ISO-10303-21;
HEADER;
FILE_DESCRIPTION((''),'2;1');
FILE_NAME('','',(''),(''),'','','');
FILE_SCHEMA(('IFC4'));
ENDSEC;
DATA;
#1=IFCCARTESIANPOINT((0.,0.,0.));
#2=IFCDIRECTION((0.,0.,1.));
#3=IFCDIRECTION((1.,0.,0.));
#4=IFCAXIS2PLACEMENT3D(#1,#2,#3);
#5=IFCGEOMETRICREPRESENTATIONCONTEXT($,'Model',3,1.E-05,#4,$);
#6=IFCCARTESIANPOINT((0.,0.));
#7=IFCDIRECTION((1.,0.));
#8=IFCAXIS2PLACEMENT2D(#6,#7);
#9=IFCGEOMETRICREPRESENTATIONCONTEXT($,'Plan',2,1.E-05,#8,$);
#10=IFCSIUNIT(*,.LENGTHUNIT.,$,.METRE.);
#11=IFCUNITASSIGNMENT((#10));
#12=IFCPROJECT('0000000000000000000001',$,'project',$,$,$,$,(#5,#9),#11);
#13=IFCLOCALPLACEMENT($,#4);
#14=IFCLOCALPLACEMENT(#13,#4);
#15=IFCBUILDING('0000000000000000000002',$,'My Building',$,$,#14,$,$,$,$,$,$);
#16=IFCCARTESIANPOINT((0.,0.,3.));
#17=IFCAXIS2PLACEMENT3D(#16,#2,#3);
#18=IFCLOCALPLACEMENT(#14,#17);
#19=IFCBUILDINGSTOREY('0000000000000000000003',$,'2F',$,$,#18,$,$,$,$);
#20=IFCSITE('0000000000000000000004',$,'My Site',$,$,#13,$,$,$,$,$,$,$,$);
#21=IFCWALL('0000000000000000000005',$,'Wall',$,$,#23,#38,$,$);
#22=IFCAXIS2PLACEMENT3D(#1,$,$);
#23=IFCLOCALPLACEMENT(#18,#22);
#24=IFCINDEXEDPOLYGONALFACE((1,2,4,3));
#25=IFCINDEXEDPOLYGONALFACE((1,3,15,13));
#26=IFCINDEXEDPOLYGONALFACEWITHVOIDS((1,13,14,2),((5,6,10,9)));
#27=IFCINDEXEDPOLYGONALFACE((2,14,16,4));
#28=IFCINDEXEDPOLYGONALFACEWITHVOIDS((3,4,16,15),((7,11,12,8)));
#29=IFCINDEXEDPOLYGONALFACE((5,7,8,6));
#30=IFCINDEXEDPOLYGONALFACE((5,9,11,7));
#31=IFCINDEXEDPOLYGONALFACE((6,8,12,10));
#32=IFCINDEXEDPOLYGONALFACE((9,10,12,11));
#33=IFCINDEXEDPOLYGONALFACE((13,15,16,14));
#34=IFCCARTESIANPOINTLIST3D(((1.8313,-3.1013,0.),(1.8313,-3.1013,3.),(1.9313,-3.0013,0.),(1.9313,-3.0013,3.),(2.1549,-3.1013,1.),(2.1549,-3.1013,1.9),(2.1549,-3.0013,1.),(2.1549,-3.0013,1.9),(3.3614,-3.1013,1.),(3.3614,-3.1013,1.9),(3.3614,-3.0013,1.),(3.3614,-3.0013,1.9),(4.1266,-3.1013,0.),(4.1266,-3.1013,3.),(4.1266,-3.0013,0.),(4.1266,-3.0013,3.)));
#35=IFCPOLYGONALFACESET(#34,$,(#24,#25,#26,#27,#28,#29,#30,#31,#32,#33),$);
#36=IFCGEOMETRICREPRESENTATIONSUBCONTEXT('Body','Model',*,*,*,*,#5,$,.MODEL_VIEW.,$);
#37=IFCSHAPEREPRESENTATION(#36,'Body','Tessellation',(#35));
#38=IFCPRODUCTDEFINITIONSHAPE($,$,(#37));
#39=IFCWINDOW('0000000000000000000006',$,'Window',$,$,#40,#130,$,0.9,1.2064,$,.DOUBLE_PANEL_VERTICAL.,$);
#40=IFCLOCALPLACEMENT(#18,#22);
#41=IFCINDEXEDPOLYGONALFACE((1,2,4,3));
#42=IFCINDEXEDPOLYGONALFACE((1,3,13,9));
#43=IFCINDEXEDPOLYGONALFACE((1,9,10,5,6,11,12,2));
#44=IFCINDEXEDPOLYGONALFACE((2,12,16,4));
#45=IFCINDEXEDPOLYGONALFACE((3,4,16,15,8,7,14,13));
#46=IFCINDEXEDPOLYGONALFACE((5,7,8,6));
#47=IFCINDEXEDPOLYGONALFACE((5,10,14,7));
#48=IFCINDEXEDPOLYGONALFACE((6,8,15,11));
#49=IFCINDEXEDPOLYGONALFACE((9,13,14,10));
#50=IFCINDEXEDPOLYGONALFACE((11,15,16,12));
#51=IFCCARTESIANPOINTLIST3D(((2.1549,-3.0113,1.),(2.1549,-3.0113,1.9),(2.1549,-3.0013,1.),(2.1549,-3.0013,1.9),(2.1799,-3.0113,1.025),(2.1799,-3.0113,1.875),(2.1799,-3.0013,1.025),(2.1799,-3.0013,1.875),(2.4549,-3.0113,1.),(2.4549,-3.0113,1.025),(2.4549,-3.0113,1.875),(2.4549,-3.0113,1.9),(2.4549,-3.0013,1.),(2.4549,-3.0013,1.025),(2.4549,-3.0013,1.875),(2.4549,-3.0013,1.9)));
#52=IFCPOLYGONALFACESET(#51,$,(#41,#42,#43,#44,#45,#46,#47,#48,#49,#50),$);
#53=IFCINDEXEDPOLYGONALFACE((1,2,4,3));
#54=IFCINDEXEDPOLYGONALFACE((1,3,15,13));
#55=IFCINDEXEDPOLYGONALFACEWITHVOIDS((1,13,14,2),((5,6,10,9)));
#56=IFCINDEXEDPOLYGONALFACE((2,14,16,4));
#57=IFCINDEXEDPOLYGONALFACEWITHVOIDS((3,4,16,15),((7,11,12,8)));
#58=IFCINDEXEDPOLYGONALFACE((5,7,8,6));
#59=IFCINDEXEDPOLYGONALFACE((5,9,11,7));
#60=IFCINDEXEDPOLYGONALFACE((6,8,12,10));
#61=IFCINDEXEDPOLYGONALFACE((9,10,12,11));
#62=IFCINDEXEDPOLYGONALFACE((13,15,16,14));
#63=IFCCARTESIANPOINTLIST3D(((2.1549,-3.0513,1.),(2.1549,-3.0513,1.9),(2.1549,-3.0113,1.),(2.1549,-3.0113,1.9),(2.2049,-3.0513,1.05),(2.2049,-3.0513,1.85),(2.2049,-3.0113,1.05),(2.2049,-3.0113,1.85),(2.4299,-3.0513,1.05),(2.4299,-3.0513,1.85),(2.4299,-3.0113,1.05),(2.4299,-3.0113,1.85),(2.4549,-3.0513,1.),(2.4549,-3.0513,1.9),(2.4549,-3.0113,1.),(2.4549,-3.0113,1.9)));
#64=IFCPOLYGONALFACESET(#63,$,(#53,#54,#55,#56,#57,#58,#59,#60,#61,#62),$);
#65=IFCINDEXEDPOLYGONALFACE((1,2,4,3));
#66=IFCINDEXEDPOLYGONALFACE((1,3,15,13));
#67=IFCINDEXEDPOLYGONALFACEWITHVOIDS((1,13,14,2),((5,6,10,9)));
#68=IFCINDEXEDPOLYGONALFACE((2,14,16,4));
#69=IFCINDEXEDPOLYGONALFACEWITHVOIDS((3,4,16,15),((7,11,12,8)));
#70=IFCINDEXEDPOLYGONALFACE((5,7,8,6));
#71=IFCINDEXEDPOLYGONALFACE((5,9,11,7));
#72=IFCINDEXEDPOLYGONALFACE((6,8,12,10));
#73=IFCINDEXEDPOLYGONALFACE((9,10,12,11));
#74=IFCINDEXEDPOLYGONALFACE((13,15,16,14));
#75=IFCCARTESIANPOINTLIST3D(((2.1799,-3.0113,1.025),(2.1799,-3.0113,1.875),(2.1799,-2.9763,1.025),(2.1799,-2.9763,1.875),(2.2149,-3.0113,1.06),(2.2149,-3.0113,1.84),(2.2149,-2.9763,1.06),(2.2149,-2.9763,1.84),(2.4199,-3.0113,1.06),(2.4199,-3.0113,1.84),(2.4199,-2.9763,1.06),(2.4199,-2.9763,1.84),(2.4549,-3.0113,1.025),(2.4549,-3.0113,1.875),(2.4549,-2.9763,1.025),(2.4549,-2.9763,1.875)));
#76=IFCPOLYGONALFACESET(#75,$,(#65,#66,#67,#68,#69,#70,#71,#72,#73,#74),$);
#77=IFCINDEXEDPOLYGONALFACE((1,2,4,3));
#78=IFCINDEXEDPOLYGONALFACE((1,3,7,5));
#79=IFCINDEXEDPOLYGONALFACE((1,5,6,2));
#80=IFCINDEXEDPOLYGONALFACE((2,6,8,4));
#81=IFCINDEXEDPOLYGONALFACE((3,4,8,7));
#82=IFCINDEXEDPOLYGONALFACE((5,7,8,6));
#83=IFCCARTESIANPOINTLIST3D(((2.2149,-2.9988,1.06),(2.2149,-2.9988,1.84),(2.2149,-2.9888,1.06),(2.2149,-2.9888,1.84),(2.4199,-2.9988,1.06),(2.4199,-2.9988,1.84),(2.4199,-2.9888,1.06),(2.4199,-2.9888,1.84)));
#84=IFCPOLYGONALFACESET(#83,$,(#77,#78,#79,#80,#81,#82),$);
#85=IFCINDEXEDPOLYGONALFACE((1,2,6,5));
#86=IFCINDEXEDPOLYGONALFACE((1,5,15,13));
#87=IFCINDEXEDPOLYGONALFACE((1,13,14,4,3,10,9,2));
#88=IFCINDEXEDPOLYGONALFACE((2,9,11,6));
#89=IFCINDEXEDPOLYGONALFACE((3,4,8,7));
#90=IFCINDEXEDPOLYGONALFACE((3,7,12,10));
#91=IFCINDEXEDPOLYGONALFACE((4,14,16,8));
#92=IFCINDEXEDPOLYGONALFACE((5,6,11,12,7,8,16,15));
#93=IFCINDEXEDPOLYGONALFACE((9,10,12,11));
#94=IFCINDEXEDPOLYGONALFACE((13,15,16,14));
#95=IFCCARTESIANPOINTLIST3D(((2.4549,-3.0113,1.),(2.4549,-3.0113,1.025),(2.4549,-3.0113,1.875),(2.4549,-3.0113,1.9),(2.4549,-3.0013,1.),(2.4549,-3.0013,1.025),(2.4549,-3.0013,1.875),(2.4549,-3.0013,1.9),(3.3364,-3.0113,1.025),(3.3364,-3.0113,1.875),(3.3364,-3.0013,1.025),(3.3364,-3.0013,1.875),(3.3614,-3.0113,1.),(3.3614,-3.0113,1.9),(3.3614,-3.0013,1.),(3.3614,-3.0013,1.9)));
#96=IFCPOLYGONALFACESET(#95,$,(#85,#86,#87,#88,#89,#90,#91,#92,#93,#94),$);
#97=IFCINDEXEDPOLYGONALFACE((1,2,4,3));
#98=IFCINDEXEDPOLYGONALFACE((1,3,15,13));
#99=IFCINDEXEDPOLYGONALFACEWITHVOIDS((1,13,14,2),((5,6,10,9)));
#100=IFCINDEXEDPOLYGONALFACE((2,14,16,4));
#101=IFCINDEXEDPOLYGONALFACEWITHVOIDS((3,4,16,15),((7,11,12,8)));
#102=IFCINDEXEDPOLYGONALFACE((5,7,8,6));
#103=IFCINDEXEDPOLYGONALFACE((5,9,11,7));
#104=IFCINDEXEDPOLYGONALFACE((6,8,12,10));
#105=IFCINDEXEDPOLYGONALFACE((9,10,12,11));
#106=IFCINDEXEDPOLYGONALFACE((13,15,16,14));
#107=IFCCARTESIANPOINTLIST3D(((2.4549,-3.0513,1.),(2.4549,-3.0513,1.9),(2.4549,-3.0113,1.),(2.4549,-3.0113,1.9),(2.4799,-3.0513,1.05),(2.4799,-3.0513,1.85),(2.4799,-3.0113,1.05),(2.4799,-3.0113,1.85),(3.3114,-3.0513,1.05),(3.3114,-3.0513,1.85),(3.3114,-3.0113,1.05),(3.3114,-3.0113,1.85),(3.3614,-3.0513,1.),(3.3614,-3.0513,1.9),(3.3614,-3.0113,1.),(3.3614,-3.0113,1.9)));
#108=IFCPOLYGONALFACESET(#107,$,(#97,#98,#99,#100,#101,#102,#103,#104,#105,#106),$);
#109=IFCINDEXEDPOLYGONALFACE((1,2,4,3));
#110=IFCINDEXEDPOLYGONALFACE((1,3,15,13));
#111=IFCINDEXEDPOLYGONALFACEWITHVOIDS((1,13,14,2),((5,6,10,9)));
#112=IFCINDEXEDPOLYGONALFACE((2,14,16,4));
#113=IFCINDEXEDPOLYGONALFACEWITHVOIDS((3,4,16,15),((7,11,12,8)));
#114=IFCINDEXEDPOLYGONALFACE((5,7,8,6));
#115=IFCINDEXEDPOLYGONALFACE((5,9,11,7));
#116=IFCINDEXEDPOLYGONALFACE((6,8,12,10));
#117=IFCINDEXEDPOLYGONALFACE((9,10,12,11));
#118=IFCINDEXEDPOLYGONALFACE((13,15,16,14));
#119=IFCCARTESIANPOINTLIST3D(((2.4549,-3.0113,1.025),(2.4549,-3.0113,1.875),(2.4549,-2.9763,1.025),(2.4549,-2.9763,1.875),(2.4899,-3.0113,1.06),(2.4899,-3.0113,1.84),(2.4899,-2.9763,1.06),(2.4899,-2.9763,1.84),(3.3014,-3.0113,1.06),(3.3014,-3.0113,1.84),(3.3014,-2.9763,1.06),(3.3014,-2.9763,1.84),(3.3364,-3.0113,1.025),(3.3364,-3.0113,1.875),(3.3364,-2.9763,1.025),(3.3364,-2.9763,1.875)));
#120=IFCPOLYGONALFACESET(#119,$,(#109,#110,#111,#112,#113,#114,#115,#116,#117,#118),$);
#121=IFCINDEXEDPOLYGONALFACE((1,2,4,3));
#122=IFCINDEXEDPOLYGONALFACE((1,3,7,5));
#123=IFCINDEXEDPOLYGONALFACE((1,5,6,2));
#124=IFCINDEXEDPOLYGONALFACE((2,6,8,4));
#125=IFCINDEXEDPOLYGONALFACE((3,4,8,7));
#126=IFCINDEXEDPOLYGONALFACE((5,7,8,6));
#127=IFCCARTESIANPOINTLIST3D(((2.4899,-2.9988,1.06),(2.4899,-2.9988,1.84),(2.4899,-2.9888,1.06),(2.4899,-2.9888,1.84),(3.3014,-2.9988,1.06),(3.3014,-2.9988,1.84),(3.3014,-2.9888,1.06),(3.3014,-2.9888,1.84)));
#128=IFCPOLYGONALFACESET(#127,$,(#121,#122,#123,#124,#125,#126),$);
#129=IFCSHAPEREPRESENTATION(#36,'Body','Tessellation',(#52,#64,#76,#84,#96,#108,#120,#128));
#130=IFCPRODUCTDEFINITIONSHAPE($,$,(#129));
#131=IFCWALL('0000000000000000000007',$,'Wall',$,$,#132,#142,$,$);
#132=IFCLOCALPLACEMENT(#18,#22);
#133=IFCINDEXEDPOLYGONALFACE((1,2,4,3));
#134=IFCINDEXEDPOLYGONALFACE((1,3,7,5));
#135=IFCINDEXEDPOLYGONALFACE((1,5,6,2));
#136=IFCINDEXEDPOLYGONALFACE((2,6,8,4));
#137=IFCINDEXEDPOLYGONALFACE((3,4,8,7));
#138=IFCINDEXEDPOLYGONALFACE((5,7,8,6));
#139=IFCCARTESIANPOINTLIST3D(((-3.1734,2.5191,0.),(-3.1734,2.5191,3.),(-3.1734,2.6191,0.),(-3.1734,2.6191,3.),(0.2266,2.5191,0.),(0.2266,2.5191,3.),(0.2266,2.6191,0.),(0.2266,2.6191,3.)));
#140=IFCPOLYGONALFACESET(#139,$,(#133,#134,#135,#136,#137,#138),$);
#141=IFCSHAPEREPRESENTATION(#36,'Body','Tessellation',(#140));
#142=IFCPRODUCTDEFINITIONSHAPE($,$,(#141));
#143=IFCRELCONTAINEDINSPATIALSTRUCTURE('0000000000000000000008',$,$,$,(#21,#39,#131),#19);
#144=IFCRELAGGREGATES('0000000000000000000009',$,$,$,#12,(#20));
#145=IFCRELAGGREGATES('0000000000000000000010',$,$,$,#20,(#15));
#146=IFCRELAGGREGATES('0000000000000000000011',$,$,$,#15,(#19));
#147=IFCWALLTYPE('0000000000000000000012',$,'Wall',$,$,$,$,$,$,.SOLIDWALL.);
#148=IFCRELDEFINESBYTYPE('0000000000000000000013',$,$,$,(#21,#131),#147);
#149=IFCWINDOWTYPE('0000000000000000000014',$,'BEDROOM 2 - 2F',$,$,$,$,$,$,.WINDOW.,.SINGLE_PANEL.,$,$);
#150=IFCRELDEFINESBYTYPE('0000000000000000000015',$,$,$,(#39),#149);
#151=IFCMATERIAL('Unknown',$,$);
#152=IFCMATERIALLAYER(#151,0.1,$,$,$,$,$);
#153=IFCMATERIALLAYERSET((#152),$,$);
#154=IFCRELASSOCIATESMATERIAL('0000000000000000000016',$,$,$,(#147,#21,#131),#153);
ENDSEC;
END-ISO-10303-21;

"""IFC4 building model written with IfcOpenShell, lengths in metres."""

from ifc_helpers import new_model, entity, si_unit, frame, origin_with_axes, origin_2d_with_axis, place, context, subcontext, project, spatial, line, indexed_curve, outline, extrude, shape, source, transform, mapped, material, layer, layer_set, layer_usage, type_object, type_shapes, element, fill, save


model = new_model("IFC4")

# Units and contexts
model_context = context("Model", 3, precision=1e-05, world=origin_with_axes())
plan_context = context("Plan", 2, precision=1e-05, world=origin_2d_with_axis())
body_context_1 = subcontext(model_context, "Body", "Model", "MODEL_VIEW")
body_context_2 = subcontext(plan_context, "Body", "Plan", "PLAN_VIEW")
ifc_project = project(units=[si_unit("LENGTHUNIT", "METRE")], contexts=[model_context, plan_context])

# Site, building, storey
site_placement = place(None, origin_with_axes())
site = spatial("IfcSite", under=ifc_project, at=site_placement, Name="My Site")
building_placement = place(site_placement, origin_with_axes())
building = spatial("IfcBuilding", under=site, at=building_placement, Name="My Building")
storey_placement = place(building_placement, frame((0.0, 0.0, 3.0), z_axis=(0.0, 0.0, 1.0), x_axis=(1.0, 0.0, 0.0)))
storey = spatial("IfcBuildingStorey", under=building, at=storey_placement, Name="2F")

# Shared definitions
ifc_material = material(Name="Unknown")

# Shared definitions
ifc_layer_1 = layer(ifc_material, 0.1)
ifc_layer_set_1 = layer_set([ifc_layer_1])
wall_type = type_object("IfcWallType", Name="Wall", PredefinedType="SOLIDWALL", material=ifc_layer_set_1)

# Wall, opening, window
ifc_layer_usage_1 = layer_usage(ifc_layer_set_1, "AXIS2", "POSITIVE", 0.0)
wall_1_placement = place(storey_placement, frame((1.8313, -3.1013, 0.0), z_axis=(0.0, 0.0, 1.0), x_axis=(1.0, 0.0, 0.0)))
wall_1 = element("IfcWall", 1, at=wall_1_placement, inside=storey, type_object=wall_type, material=ifc_layer_usage_1, Name="Wall", context=body_context_1, shape_type="SweptSolid", body=[
    extrude(outline(indexed_curve([(0.0, 0.0), (0.1, 0.1), (2.2953, 0.1), (2.2953, 0.0)], segments=[line(1, 2, 3, 4, 1)])), origin_with_axes(), (0.0, 0.0, 1.0), 3.0),
])
shared_shape_1 = source(origin_with_axes(), body_context_1, "Body", "SweptSolid", [
    extrude(outline(indexed_curve([(0.0, 0.0), (1.2064, 0.0), (1.2064, 0.9), (0.0, 0.9)], segments=[line(1, 2, 3, 4, 1)])), frame((0.0, -0.6, 0.0), z_axis=(0.0, -1.0, 0.0), x_axis=(1.0, 0.0, 0.0)), (0.0, 0.0, -1.0), 1.2),
])
opening_1_placement = place(wall_1_placement, frame((0.3236, 0.0, 1.0), z_axis=(0.0, 0.0, 1.0), x_axis=(1.0, 0.0, 0.0)))
opening_1 = element("IfcOpeningElement", 2, at=opening_1_placement, cuts=wall_1, PredefinedType="OPENING", context=body_context_1, shape_type="MappedRepresentation", body=[
    mapped(shared_shape_1, transform((0.0, 0.0, 0.0), x_axis=(1.0, 0.0, 0.0), y_axis=(0.0, 1.0, 0.0), z_axis=(0.0, 0.0, 1.0), scale=1.0)),
])
window_type_1 = type_object("IfcWindowType", Name="BEDROOM 2 - 2F", PartitioningType="SINGLE_PANEL", PredefinedType="WINDOW")
shared_shape_2 = source(origin_with_axes(), body_context_1, "Body", "SweptSolid", [
    extrude(outline(indexed_curve([(0.3, 0.0), (0.0, 0.0), (0.0, 0.9), (0.3, 0.9), (0.3, 0.875), (0.025, 0.875), (0.025, 0.025), (0.3, 0.025)], segments=[line(1, 2, 3, 4, 5, 6, 7, 8, 1)])), frame((0.0, 0.09, 0.0), z_axis=(0.0, -1.0, 0.0), x_axis=(1.0, 0.0, 0.0)), (0.0, 0.0, -1.0), 0.01),
    extrude(outline(indexed_curve([(0.0, 0.0), (0.3, 0.0), (0.3, 0.9), (0.0, 0.9)], segments=[line(1, 2, 3, 4, 1)]), holes=[indexed_curve([(0.05, 0.05), (0.275, 0.05), (0.275, 0.85), (0.05, 0.85)], segments=[line(1, 2, 3, 4, 1)])]), frame((0.0, 0.05, 0.0), z_axis=(0.0, -1.0, 0.0), x_axis=(1.0, 0.0, 0.0)), (0.0, 0.0, -1.0), 0.04),
    extrude(outline(indexed_curve([(0.0, 0.0), (0.275, 0.0), (0.275, 0.85), (0.0, 0.85)], segments=[line(1, 2, 3, 4, 1)]), holes=[indexed_curve([(0.035, 0.035), (0.24, 0.035), (0.24, 0.815), (0.035, 0.815)], segments=[line(1, 2, 3, 4, 1)])]), frame((0.025, 0.09, 0.025), z_axis=(0.0, -1.0, 0.0), x_axis=(1.0, 0.0, 0.0)), (0.0, 0.0, -1.0), 0.035),
    extrude(outline(indexed_curve([(0.035, 0.035), (0.24, 0.035), (0.24, 0.815), (0.035, 0.815)], segments=[line(1, 2, 3, 4, 1)])), frame((0.025, 0.1025, 0.025), z_axis=(0.0, -1.0, 0.0), x_axis=(1.0, 0.0, 0.0)), (0.0, 0.0, -1.0), 0.01),
    extrude(outline(indexed_curve([(0.0, 0.9), (0.9064, 0.9), (0.9064, 0.0), (0.0, 0.0), (0.0, 0.025), (0.8814, 0.025), (0.8814, 0.875), (0.0, 0.875)], segments=[line(1, 2, 3, 4, 5, 6, 7, 8, 1)])), frame((0.3, 0.09, 0.0), z_axis=(0.0, -1.0, 0.0), x_axis=(1.0, 0.0, 0.0)), (0.0, 0.0, -1.0), 0.01),
    extrude(outline(indexed_curve([(0.0, 0.0), (0.9064, 0.0), (0.9064, 0.9), (0.0, 0.9)], segments=[line(1, 2, 3, 4, 1)]), holes=[indexed_curve([(0.025, 0.05), (0.8564, 0.05), (0.8564, 0.85), (0.025, 0.85)], segments=[line(1, 2, 3, 4, 1)])]), frame((0.3, 0.05, 0.0), z_axis=(0.0, -1.0, 0.0), x_axis=(1.0, 0.0, 0.0)), (0.0, 0.0, -1.0), 0.04),
    extrude(outline(indexed_curve([(0.0, 0.0), (0.8814, 0.0), (0.8814, 0.85), (0.0, 0.85)], segments=[line(1, 2, 3, 4, 1)]), holes=[indexed_curve([(0.035, 0.035), (0.8464, 0.035), (0.8464, 0.815), (0.035, 0.815)], segments=[line(1, 2, 3, 4, 1)])]), frame((0.3, 0.09, 0.025), z_axis=(0.0, -1.0, 0.0), x_axis=(1.0, 0.0, 0.0)), (0.0, 0.0, -1.0), 0.035),
    extrude(outline(indexed_curve([(0.035, 0.035), (0.8464, 0.035), (0.8464, 0.815), (0.035, 0.815)], segments=[line(1, 2, 3, 4, 1)])), frame((0.3, 0.1025, 0.025), z_axis=(0.0, -1.0, 0.0), x_axis=(1.0, 0.0, 0.0)), (0.0, 0.0, -1.0), 0.01),
])
shared_shape_3 = source(origin_with_axes(), body_context_2, "Body", "Curve2D", [
    entity("IfcIndexedPolyCurve", entity("IfcCartesianPointList2D", [[0.05, 0.05], [0.275, 0.05]])),
    entity("IfcIndexedPolyCurve", entity("IfcCartesianPointList2D", [[0.0, 0.1], [0.025, 0.1], [0.025, 0.09], [0.05, 0.09], [0.05, 0.05], [0.0, 0.05]]), [entity("IfcLineIndex", [1, 2, 3, 4, 5, 6, 1])]),
    entity("IfcIndexedPolyCurve", entity("IfcCartesianPointList2D", [[0.3, 0.1], [0.3, 0.1], [0.3, 0.09], [0.275, 0.09], [0.275, 0.05], [0.3, 0.05]])),
    entity("IfcIndexedPolyCurve", entity("IfcCartesianPointList2D", [[0.025, 0.09], [0.06, 0.09], [0.06, 0.125], [0.025, 0.125]]), [entity("IfcLineIndex", [1, 2, 3, 4, 1])]),
    entity("IfcIndexedPolyCurve", entity("IfcCartesianPointList2D", [[0.3, 0.09], [0.265, 0.09], [0.265, 0.125], [0.3, 0.125]]), [entity("IfcLineIndex", [1, 2, 3, 4, 1])]),
    entity("IfcIndexedPolyCurve", entity("IfcCartesianPointList2D", [[0.06, 0.09], [0.265, 0.09]])),
    entity("IfcIndexedPolyCurve", entity("IfcCartesianPointList2D", [[0.06, 0.125], [0.265, 0.125]])),
    entity("IfcIndexedPolyCurve", entity("IfcCartesianPointList2D", [[0.06, 0.1075], [0.265, 0.1075]])),
    entity("IfcIndexedPolyCurve", entity("IfcCartesianPointList2D", [[0.325, 0.05], [1.1564, 0.05]])),
    entity("IfcIndexedPolyCurve", entity("IfcCartesianPointList2D", [[0.3, 0.1], [0.3, 0.1], [0.3, 0.09], [0.325, 0.09], [0.325, 0.05], [0.3, 0.05]])),
    entity("IfcIndexedPolyCurve", entity("IfcCartesianPointList2D", [[1.2064, 0.1], [1.1814, 0.1], [1.1814, 0.09], [1.1564, 0.09], [1.1564, 0.05], [1.2064, 0.05]]), [entity("IfcLineIndex", [1, 2, 3, 4, 5, 6, 1])]),
    entity("IfcIndexedPolyCurve", entity("IfcCartesianPointList2D", [[0.3, 0.09], [0.335, 0.09], [0.335, 0.125], [0.3, 0.125]]), [entity("IfcLineIndex", [1, 2, 3, 4, 1])]),
    entity("IfcIndexedPolyCurve", entity("IfcCartesianPointList2D", [[1.1814, 0.09], [1.1464, 0.09], [1.1464, 0.125], [1.1814, 0.125]]), [entity("IfcLineIndex", [1, 2, 3, 4, 1])]),
    entity("IfcIndexedPolyCurve", entity("IfcCartesianPointList2D", [[0.335, 0.09], [1.1464, 0.09]])),
    entity("IfcIndexedPolyCurve", entity("IfcCartesianPointList2D", [[0.335, 0.125], [1.1464, 0.125]])),
    entity("IfcIndexedPolyCurve", entity("IfcCartesianPointList2D", [[0.335, 0.1075], [1.1464, 0.1075]])),
])
type_shapes(window_type_1, [shared_shape_2, shared_shape_3])
window_1_placement = place(opening_1_placement, origin_with_axes())
window_1 = element("IfcWindow", 3, at=window_1_placement, inside=storey, type_object=window_type_1, Name="Window", OverallHeight=0.9, OverallWidth=1.2064, PartitioningType="DOUBLE_PANEL_VERTICAL", shapes=[
    shape(body_context_1, "Body", "MappedRepresentation", [mapped(shared_shape_2, transform((0.0, 0.0, 0.0), x_axis=(1.0, 0.0, 0.0), y_axis=(0.0, 1.0, 0.0), z_axis=(0.0, 0.0, 1.0), scale=1.0))]),
    shape(body_context_2, "Body", "MappedRepresentation", [mapped(shared_shape_3, transform((0.0, 0.0, 0.0), x_axis=(1.0, 0.0, 0.0), y_axis=(0.0, 1.0, 0.0), z_axis=(0.0, 0.0, 1.0), scale=1.0))]),
])
fill(opening_1, window_1)

# Wall
ifc_layer_usage_2 = layer_usage(ifc_layer_set_1, "AXIS2", "POSITIVE", 0.0)
wall_2_placement = place(storey_placement, frame((-3.1734, 2.5191, 0.0), z_axis=(0.0, 0.0, 1.0), x_axis=(1.0, 0.0, 0.0)))
element("IfcWall", 4, at=wall_2_placement, inside=storey, type_object=wall_type, material=ifc_layer_usage_2, Name="Wall", context=body_context_1, shape_type="SweptSolid", body=[
    extrude(outline(indexed_curve([(0.0, 0.0), (0.0, 0.1), (3.4, 0.1), (3.4, 0.0)], segments=[line(1, 2, 3, 4, 1)])), origin_with_axes(), (0.0, 0.0, 1.0), 3.0),
])

save(model, "model.ifc")
